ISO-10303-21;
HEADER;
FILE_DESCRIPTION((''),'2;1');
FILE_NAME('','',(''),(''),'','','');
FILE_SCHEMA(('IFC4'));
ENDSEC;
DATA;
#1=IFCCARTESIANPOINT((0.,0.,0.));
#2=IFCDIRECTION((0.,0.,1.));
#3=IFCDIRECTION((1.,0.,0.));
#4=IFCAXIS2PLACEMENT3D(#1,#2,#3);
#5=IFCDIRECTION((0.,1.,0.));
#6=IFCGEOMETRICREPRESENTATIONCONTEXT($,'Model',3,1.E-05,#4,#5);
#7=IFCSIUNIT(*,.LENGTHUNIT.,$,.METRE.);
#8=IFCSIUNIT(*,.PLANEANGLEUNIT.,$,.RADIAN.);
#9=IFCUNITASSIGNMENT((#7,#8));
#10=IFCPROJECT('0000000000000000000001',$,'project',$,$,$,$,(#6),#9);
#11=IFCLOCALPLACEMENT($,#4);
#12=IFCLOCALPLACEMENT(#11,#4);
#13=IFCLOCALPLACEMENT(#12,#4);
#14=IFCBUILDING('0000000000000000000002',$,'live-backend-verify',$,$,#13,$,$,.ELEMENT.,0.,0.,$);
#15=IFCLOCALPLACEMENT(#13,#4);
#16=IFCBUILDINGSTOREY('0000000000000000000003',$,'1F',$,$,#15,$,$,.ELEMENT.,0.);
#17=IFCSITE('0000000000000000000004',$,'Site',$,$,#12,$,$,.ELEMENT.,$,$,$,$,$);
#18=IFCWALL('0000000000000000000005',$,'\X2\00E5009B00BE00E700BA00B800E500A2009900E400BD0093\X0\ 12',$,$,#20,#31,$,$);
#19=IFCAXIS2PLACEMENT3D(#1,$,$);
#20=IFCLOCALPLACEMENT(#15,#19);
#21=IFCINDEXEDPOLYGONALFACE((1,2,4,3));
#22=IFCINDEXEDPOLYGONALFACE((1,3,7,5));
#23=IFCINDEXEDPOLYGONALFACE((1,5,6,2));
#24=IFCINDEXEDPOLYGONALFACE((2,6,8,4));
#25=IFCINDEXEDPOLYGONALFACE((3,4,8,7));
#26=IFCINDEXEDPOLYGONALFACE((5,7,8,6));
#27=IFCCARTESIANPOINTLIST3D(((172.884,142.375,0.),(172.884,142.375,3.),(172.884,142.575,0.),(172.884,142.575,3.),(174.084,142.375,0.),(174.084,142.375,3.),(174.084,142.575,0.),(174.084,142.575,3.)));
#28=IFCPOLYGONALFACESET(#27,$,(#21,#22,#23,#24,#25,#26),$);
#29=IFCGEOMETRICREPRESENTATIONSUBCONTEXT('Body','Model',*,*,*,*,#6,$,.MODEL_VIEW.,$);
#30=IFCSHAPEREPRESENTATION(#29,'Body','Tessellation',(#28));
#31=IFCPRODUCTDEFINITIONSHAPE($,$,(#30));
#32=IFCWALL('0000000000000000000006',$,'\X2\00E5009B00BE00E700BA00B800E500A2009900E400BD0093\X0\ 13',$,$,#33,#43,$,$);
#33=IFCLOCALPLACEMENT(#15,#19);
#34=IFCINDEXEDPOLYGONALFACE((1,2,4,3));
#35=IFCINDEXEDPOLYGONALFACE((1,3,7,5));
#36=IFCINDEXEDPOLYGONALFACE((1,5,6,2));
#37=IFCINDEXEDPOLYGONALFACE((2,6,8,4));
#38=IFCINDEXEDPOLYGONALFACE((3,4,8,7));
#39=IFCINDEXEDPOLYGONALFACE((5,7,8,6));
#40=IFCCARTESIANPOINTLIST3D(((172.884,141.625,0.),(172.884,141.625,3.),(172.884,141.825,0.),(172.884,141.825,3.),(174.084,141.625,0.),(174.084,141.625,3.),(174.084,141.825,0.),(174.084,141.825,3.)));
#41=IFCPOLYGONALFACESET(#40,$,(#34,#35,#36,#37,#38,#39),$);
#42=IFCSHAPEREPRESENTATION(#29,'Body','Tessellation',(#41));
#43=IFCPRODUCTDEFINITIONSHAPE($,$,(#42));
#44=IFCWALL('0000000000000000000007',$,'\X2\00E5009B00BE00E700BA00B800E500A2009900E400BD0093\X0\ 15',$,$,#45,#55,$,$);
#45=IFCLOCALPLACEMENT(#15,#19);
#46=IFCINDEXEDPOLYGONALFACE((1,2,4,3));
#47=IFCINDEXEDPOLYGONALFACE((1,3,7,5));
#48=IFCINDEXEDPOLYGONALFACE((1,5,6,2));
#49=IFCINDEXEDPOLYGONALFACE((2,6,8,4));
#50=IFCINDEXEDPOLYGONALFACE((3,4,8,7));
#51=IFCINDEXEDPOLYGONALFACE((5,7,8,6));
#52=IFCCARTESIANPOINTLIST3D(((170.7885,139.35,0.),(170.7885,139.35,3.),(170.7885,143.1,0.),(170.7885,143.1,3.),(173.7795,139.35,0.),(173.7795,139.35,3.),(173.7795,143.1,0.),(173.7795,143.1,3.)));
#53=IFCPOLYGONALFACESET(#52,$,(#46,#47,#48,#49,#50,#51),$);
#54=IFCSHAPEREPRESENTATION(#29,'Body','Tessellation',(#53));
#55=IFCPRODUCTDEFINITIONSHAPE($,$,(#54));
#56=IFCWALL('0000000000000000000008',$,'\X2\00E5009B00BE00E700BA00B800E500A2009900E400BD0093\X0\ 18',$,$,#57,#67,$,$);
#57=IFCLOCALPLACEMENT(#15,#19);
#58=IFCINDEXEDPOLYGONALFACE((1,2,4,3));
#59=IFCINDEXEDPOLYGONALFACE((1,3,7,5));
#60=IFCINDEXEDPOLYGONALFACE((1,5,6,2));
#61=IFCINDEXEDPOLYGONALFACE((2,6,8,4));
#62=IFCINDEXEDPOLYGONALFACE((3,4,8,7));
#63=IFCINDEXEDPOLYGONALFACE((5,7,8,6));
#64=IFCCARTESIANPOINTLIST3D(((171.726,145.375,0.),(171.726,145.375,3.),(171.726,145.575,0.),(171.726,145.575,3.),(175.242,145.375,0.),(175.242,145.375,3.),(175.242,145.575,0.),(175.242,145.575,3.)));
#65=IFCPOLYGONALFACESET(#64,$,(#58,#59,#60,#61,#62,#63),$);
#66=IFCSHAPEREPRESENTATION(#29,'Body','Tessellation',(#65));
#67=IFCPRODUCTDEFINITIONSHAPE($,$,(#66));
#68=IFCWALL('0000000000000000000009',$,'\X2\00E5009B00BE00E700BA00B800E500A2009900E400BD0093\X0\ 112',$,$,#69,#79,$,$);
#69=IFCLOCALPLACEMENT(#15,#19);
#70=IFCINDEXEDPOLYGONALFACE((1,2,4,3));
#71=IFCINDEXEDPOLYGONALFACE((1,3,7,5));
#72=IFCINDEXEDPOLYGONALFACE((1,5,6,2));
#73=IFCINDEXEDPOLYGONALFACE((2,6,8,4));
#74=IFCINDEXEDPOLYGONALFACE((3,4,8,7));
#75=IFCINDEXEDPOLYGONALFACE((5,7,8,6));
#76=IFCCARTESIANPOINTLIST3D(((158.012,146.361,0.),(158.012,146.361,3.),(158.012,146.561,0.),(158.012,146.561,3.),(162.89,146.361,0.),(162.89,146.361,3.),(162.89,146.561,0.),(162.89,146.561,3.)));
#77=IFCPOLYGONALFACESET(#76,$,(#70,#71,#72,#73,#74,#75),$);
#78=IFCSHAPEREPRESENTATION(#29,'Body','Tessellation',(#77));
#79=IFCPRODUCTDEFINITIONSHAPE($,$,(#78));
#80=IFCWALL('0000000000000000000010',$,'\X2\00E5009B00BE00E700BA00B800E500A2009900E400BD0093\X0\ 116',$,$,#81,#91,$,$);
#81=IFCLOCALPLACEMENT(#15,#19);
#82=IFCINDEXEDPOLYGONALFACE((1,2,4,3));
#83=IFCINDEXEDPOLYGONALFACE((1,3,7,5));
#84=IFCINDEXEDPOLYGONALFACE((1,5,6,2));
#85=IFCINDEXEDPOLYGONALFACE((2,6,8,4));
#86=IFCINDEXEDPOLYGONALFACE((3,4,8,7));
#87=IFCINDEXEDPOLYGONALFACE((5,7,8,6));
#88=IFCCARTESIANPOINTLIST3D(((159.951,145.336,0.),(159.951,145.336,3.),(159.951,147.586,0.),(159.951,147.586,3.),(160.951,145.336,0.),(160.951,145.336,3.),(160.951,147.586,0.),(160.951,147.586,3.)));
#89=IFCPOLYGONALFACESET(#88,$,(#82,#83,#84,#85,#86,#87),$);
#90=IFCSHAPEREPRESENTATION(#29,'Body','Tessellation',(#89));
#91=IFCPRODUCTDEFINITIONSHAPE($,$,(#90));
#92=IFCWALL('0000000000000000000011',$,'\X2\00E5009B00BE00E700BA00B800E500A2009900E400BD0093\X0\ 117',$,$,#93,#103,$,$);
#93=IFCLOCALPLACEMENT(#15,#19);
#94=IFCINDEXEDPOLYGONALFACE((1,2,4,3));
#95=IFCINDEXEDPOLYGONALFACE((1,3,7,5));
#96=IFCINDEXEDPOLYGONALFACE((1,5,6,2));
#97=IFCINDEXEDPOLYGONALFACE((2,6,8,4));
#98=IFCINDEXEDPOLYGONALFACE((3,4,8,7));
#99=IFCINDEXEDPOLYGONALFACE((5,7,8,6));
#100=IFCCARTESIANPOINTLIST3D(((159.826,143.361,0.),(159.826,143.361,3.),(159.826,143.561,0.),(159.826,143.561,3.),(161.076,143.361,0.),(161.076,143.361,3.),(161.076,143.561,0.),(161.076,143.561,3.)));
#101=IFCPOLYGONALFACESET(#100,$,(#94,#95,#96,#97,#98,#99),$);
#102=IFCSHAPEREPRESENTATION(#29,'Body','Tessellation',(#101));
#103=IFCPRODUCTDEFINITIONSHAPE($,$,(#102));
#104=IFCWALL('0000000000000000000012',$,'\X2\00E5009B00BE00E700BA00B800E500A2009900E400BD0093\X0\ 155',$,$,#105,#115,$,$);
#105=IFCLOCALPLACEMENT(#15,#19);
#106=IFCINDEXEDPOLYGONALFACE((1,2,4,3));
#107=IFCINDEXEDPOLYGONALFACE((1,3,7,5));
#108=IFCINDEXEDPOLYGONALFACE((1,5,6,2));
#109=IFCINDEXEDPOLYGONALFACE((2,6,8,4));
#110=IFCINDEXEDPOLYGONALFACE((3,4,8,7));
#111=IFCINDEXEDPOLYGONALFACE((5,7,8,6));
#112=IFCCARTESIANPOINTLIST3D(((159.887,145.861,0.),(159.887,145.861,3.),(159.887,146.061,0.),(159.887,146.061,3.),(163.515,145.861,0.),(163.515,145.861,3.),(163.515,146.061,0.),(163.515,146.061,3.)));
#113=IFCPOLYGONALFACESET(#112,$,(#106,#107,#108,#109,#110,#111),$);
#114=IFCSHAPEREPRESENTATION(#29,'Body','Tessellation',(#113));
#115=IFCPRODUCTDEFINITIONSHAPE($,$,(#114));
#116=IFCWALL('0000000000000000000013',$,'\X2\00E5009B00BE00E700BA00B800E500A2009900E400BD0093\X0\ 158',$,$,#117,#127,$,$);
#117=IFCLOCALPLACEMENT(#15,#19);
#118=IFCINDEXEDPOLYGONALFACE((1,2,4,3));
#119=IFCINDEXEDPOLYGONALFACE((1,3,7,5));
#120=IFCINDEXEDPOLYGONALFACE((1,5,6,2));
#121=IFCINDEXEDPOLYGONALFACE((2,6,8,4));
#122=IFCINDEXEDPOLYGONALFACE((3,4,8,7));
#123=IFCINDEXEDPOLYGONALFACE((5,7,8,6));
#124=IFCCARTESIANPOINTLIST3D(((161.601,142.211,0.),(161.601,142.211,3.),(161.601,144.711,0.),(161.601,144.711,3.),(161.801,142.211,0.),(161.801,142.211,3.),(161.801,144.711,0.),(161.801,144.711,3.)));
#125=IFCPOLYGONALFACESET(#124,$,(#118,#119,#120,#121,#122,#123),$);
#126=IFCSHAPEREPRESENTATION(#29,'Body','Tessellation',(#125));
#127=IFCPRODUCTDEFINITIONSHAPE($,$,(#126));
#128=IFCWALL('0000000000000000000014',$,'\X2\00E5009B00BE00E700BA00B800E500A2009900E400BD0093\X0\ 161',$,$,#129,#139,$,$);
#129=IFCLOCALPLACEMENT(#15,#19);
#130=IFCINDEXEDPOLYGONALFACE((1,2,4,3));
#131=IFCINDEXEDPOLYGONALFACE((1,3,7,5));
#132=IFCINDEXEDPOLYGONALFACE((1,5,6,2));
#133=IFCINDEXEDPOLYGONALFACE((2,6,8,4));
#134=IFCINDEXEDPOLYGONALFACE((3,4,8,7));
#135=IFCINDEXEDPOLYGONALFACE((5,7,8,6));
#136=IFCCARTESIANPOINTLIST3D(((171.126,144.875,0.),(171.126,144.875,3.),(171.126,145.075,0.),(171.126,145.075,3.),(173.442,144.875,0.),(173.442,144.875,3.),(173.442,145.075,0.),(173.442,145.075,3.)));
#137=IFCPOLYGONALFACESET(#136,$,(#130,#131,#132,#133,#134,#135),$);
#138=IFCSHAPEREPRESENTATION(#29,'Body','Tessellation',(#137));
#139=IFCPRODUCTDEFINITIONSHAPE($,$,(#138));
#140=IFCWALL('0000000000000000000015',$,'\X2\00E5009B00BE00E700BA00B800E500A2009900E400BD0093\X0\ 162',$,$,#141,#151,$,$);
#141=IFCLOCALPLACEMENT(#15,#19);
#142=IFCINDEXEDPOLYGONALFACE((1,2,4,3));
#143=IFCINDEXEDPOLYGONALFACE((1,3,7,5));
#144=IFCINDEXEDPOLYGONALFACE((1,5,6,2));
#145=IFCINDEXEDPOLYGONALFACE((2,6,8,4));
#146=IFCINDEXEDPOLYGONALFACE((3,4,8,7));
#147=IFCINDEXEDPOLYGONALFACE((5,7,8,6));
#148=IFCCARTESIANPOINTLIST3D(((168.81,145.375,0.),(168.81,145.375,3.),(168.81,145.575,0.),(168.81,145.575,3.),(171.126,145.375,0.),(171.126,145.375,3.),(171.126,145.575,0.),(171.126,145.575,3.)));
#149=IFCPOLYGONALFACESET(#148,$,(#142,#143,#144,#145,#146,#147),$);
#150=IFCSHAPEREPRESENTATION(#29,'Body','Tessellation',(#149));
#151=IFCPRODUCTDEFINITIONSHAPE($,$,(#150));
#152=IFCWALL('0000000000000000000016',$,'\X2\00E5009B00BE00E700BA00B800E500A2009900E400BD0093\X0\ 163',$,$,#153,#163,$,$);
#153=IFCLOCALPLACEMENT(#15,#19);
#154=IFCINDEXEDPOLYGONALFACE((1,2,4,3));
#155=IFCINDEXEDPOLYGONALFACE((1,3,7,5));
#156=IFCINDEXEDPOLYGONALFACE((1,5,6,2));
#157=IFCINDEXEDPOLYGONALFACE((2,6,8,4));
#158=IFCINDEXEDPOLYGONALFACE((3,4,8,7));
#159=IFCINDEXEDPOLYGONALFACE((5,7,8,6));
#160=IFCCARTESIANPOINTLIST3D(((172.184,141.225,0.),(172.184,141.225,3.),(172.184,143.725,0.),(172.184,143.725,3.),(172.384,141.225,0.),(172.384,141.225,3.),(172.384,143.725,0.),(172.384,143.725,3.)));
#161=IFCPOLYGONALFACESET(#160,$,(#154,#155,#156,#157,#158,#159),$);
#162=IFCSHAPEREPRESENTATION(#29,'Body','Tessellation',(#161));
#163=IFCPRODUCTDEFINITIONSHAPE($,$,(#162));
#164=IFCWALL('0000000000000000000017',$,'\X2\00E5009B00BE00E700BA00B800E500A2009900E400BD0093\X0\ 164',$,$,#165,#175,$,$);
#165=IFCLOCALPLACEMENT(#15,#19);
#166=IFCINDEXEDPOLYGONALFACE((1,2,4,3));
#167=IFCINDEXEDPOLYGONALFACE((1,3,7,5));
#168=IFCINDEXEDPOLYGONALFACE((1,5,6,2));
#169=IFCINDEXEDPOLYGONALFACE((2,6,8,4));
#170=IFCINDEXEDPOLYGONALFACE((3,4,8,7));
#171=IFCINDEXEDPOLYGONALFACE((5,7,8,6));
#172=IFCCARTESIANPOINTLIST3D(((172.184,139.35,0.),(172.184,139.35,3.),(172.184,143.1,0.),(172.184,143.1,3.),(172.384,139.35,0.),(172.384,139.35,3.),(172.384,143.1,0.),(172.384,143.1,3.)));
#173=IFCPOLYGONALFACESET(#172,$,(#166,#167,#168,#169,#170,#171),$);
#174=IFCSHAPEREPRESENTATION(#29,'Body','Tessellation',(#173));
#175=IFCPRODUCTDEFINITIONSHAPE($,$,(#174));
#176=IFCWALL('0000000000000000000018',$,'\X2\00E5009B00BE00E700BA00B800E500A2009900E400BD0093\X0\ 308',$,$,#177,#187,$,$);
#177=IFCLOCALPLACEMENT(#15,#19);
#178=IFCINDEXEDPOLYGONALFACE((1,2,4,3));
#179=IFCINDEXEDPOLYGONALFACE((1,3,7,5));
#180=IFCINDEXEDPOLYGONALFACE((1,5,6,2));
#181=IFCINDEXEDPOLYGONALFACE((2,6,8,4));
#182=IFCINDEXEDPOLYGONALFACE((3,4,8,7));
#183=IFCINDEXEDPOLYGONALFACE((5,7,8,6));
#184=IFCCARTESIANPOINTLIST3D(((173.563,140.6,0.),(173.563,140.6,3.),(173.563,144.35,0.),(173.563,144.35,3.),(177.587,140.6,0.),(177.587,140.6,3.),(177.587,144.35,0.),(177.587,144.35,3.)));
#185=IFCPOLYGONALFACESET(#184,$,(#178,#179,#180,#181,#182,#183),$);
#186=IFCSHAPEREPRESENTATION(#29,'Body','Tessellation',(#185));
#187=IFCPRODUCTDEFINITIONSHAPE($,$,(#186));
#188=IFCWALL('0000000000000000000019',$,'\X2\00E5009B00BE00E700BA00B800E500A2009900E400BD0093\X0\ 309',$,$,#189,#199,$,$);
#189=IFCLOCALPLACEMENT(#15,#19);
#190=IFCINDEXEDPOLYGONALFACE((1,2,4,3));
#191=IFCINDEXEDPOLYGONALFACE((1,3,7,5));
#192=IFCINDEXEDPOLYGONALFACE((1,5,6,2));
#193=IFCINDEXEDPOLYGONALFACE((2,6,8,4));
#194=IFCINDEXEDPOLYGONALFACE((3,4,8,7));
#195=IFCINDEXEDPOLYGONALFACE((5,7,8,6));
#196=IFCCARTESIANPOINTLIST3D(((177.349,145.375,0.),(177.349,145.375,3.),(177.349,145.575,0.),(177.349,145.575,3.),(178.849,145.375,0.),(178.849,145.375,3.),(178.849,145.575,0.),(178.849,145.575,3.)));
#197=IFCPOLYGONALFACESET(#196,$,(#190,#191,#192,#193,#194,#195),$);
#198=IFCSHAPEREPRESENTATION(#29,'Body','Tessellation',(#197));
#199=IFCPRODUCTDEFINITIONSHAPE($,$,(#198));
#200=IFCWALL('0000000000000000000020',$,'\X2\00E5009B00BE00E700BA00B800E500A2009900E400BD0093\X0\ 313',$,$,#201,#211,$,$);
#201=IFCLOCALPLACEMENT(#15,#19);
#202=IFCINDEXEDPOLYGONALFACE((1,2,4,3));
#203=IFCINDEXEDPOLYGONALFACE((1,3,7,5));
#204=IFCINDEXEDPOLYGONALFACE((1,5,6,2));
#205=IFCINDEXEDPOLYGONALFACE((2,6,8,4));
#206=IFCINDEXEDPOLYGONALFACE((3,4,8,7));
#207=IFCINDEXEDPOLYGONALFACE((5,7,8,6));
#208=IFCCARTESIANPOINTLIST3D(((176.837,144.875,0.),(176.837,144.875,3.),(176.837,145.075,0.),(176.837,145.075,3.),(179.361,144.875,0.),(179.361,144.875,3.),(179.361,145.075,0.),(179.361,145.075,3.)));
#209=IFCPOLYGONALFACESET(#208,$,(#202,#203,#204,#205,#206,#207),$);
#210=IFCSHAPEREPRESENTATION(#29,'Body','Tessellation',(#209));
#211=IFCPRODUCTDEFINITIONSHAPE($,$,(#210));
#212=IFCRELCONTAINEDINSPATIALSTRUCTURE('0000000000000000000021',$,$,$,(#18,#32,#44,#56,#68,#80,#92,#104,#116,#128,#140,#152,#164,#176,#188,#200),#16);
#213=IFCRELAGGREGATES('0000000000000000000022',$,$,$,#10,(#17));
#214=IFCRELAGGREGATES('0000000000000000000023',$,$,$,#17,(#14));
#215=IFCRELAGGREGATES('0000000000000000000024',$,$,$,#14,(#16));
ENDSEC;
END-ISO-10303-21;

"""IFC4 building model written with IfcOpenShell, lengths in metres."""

from ifc_helpers import new_model, si_unit, direction, frame, frame_2d, origin_with_axes, place, context, subcontext, project, spatial, rectangle, extrude, element, save


model = new_model("IFC4")

# Units and contexts
model_context = context("Model", 3, precision=1e-05, world=origin_with_axes(), true_north=direction((0.0, 1.0, 0.0)))
body_context = subcontext(model_context, "Body", "Model", "MODEL_VIEW")
ifc_project = project(units=[si_unit("LENGTHUNIT", "METRE"), si_unit("PLANEANGLEUNIT", "RADIAN")], contexts=[model_context])

# Site, building, storey
placement = place(None, origin_with_axes())
site_placement = place(placement, origin_with_axes())
site = spatial("IfcSite", under=ifc_project, at=site_placement, Name="Site", CompositionType="ELEMENT")
building_placement = place(site_placement, origin_with_axes())
building = spatial("IfcBuilding", under=site, at=building_placement, Name="live-backend-verify", CompositionType="ELEMENT", ElevationOfRefHeight=0.0, ElevationOfTerrain=0.0)
storey_placement = place(building_placement, origin_with_axes())
storey = spatial("IfcBuildingStorey", under=building, at=storey_placement, Name="1F", CompositionType="ELEMENT", Elevation=0.0)

# Walls
for number, where, z_axis, x_axis, name in (
    (1, (173.484, 142.475, 0.0), (0.0, 0.0, 1.0), (-1.0, 0.0, 0.0), "å\u009b¾çº¸å¢\u0099ä½\u0093 12"),
    (2, (173.484, 141.725, 0.0), (0.0, 0.0, 1.0), (-1.0, 0.0, 0.0), "å\u009b¾çº¸å¢\u0099ä½\u0093 13"),
):
    element("IfcWall", number, at=place(storey_placement, frame(where, z_axis=z_axis, x_axis=x_axis)), inside=storey, Name=name, context=body_context, shape_type="SweptSolid", body=[
        extrude(rectangle(XDim=1.2, YDim=0.2, at=frame_2d((0.0, 0.0), x_axis=(1.0, 0.0, 0.0))), frame((0.0, 0.0, 0.0), z_axis=(0.0, 0.0, 1.0)), (0.0, 0.0, 1.0), 3.0),
    ])
wall_1_placement = place(storey_placement, frame((172.284, 141.225, 0.0), z_axis=(0.0, 0.0, 1.0), x_axis=(1.0, 0.0, 0.0)))
element("IfcWall", 3, at=wall_1_placement, inside=storey, Name="å\u009b¾çº¸å¢\u0099ä½\u0093 15", context=body_context, shape_type="SweptSolid", body=[
    extrude(rectangle(XDim=2.991, YDim=3.75, at=frame_2d((0.0, 0.0), x_axis=(1.0, 0.0, 0.0))), frame((0.0, 0.0, 0.0), z_axis=(0.0, 0.0, 1.0)), (0.0, 0.0, 1.0), 3.0),
])
wall_2_placement = place(storey_placement, frame((173.484, 145.475, 0.0), z_axis=(0.0, 0.0, 1.0), x_axis=(-1.0, 0.0, 0.0)))
element("IfcWall", 4, at=wall_2_placement, inside=storey, Name="å\u009b¾çº¸å¢\u0099ä½\u0093 18", context=body_context, shape_type="SweptSolid", body=[
    extrude(rectangle(XDim=3.516, YDim=0.2, at=frame_2d((0.0, 0.0), x_axis=(1.0, 0.0, 0.0))), frame((0.0, 0.0, 0.0), z_axis=(0.0, 0.0, 1.0)), (0.0, 0.0, 1.0), 3.0),
])
for number, where, z_axis, x_axis, name in (
    (5, (160.451, 146.461, 0.0), (0.0, 0.0, 1.0), (1.0, 0.0, 0.0), "å\u009b¾çº¸å¢\u0099ä½\u0093 112"),
):
    element("IfcWall", number, at=place(storey_placement, frame(where, z_axis=z_axis, x_axis=x_axis)), inside=storey, Name=name, context=body_context, shape_type="SweptSolid", body=[
        extrude(rectangle(XDim=4.878, YDim=0.2, at=frame_2d((0.0, 0.0), x_axis=(1.0, 0.0, 0.0))), frame((0.0, 0.0, 0.0), z_axis=(0.0, 0.0, 1.0)), (0.0, 0.0, 1.0), 3.0),
    ])
wall_3_placement = place(storey_placement, frame((160.451, 146.461, 0.0), z_axis=(0.0, 0.0, 1.0), x_axis=(1.0, 0.0, 0.0)))
element("IfcWall", 6, at=wall_3_placement, inside=storey, Name="å\u009b¾çº¸å¢\u0099ä½\u0093 116", context=body_context, shape_type="SweptSolid", body=[
    extrude(rectangle(XDim=1.0, YDim=2.25, at=frame_2d((0.0, 0.0), x_axis=(1.0, 0.0, 0.0))), frame((0.0, 0.0, 0.0), z_axis=(0.0, 0.0, 1.0)), (0.0, 0.0, 1.0), 3.0),
])
wall_4_placement = place(storey_placement, frame((160.451, 143.461, 0.0), z_axis=(0.0, 0.0, 1.0), x_axis=(1.0, 0.0, 0.0)))
element("IfcWall", 7, at=wall_4_placement, inside=storey, Name="å\u009b¾çº¸å¢\u0099ä½\u0093 117", context=body_context, shape_type="SweptSolid", body=[
    extrude(rectangle(XDim=1.25, YDim=0.2, at=frame_2d((0.0, 0.0), x_axis=(1.0, 0.0, 0.0))), frame((0.0, 0.0, 0.0), z_axis=(0.0, 0.0, 1.0)), (0.0, 0.0, 1.0), 3.0),
])
for number, where, z_axis, x_axis, name in (
    (8, (161.701, 145.961, 0.0), (0.0, 0.0, 1.0), (1.0, 0.0, 0.0), "å\u009b¾çº¸å¢\u0099ä½\u0093 155"),
):
    element("IfcWall", number, at=place(storey_placement, frame(where, z_axis=z_axis, x_axis=x_axis)), inside=storey, Name=name, context=body_context, shape_type="SweptSolid", body=[
        extrude(rectangle(XDim=3.628, YDim=0.2, at=frame_2d((0.0, 0.0), x_axis=(1.0, 0.0, 0.0))), frame((0.0, 0.0, 0.0), z_axis=(0.0, 0.0, 1.0)), (0.0, 0.0, 1.0), 3.0),
    ])
wall_5_placement = place(storey_placement, frame((161.701, 143.461, 0.0), z_axis=(0.0, 0.0, 1.0), x_axis=(0.0, 1.0, 0.0)))
element("IfcWall", 9, at=wall_5_placement, inside=storey, Name="å\u009b¾çº¸å¢\u0099ä½\u0093 158", context=body_context, shape_type="SweptSolid", body=[
    extrude(rectangle(XDim=2.5, YDim=0.2, at=frame_2d((0.0, 0.0), x_axis=(1.0, 0.0, 0.0))), frame((0.0, 0.0, 0.0), z_axis=(0.0, 0.0, 1.0)), (0.0, 0.0, 1.0), 3.0),
])
for number, where, z_axis, x_axis, name in (
    (10, (172.284, 144.975, 0.0), (0.0, 0.0, 1.0), (-1.0, 0.0, 0.0), "å\u009b¾çº¸å¢\u0099ä½\u0093 161"),
    (11, (169.968, 145.475, 0.0), (0.0, 0.0, 1.0), (1.0, 0.0, 0.0), "å\u009b¾çº¸å¢\u0099ä½\u0093 162"),
):
    element("IfcWall", number, at=place(storey_placement, frame(where, z_axis=z_axis, x_axis=x_axis)), inside=storey, Name=name, context=body_context, shape_type="SweptSolid", body=[
        extrude(rectangle(XDim=2.316, YDim=0.2, at=frame_2d((0.0, 0.0), x_axis=(1.0, 0.0, 0.0))), frame((0.0, 0.0, 0.0), z_axis=(0.0, 0.0, 1.0)), (0.0, 0.0, 1.0), 3.0),
    ])
wall_6_placement = place(storey_placement, frame((172.284, 142.475, 0.0), z_axis=(0.0, 0.0, 1.0), x_axis=(0.0, 1.0, 0.0)))
element("IfcWall", 12, at=wall_6_placement, inside=storey, Name="å\u009b¾çº¸å¢\u0099ä½\u0093 163", context=body_context, shape_type="SweptSolid", body=[
    extrude(rectangle(XDim=2.5, YDim=0.2, at=frame_2d((0.0, 0.0), x_axis=(1.0, 0.0, 0.0))), frame((0.0, 0.0, 0.0), z_axis=(0.0, 0.0, 1.0)), (0.0, 0.0, 1.0), 3.0),
])
wall_7_placement = place(storey_placement, frame((172.284, 141.225, 0.0), z_axis=(0.0, 0.0, 1.0), x_axis=(0.0, 1.0, 0.0)))
element("IfcWall", 13, at=wall_7_placement, inside=storey, Name="å\u009b¾çº¸å¢\u0099ä½\u0093 164", context=body_context, shape_type="SweptSolid", body=[
    extrude(rectangle(XDim=3.75, YDim=0.2, at=frame_2d((0.0, 0.0), x_axis=(1.0, 0.0, 0.0))), frame((0.0, 0.0, 0.0), z_axis=(0.0, 0.0, 1.0)), (0.0, 0.0, 1.0), 3.0),
])
wall_8_placement = place(storey_placement, frame((175.575, 142.475, 0.0), z_axis=(0.0, 0.0, 1.0), x_axis=(1.0, 0.0, 0.0)))
element("IfcWall", 14, at=wall_8_placement, inside=storey, Name="å\u009b¾çº¸å¢\u0099ä½\u0093 308", context=body_context, shape_type="SweptSolid", body=[
    extrude(rectangle(XDim=4.024, YDim=3.75, at=frame_2d((0.0, 0.0), x_axis=(1.0, 0.0, 0.0))), frame((0.0, 0.0, 0.0), z_axis=(0.0, 0.0, 1.0)), (0.0, 0.0, 1.0), 3.0),
])
wall_9_placement = place(storey_placement, frame((178.099, 145.475, 0.0), z_axis=(0.0, 0.0, 1.0), x_axis=(1.0, 0.0, 0.0)))
element("IfcWall", 15, at=wall_9_placement, inside=storey, Name="å\u009b¾çº¸å¢\u0099ä½\u0093 309", context=body_context, shape_type="SweptSolid", body=[
    extrude(rectangle(XDim=1.5, YDim=0.2, at=frame_2d((0.0, 0.0), x_axis=(1.0, 0.0, 0.0))), frame((0.0, 0.0, 0.0), z_axis=(0.0, 0.0, 1.0)), (0.0, 0.0, 1.0), 3.0),
])
for number, where, z_axis, x_axis, name in (
    (16, (178.099, 144.975, 0.0), (0.0, 0.0, 1.0), (-1.0, 0.0, 0.0), "å\u009b¾çº¸å¢\u0099ä½\u0093 313"),
):
    element("IfcWall", number, at=place(storey_placement, frame(where, z_axis=z_axis, x_axis=x_axis)), inside=storey, Name=name, context=body_context, shape_type="SweptSolid", body=[
        extrude(rectangle(XDim=2.524, YDim=0.2, at=frame_2d((0.0, 0.0), x_axis=(1.0, 0.0, 0.0))), frame((0.0, 0.0, 0.0), z_axis=(0.0, 0.0, 1.0)), (0.0, 0.0, 1.0), 3.0),
    ])

save(model, "model.ifc")
